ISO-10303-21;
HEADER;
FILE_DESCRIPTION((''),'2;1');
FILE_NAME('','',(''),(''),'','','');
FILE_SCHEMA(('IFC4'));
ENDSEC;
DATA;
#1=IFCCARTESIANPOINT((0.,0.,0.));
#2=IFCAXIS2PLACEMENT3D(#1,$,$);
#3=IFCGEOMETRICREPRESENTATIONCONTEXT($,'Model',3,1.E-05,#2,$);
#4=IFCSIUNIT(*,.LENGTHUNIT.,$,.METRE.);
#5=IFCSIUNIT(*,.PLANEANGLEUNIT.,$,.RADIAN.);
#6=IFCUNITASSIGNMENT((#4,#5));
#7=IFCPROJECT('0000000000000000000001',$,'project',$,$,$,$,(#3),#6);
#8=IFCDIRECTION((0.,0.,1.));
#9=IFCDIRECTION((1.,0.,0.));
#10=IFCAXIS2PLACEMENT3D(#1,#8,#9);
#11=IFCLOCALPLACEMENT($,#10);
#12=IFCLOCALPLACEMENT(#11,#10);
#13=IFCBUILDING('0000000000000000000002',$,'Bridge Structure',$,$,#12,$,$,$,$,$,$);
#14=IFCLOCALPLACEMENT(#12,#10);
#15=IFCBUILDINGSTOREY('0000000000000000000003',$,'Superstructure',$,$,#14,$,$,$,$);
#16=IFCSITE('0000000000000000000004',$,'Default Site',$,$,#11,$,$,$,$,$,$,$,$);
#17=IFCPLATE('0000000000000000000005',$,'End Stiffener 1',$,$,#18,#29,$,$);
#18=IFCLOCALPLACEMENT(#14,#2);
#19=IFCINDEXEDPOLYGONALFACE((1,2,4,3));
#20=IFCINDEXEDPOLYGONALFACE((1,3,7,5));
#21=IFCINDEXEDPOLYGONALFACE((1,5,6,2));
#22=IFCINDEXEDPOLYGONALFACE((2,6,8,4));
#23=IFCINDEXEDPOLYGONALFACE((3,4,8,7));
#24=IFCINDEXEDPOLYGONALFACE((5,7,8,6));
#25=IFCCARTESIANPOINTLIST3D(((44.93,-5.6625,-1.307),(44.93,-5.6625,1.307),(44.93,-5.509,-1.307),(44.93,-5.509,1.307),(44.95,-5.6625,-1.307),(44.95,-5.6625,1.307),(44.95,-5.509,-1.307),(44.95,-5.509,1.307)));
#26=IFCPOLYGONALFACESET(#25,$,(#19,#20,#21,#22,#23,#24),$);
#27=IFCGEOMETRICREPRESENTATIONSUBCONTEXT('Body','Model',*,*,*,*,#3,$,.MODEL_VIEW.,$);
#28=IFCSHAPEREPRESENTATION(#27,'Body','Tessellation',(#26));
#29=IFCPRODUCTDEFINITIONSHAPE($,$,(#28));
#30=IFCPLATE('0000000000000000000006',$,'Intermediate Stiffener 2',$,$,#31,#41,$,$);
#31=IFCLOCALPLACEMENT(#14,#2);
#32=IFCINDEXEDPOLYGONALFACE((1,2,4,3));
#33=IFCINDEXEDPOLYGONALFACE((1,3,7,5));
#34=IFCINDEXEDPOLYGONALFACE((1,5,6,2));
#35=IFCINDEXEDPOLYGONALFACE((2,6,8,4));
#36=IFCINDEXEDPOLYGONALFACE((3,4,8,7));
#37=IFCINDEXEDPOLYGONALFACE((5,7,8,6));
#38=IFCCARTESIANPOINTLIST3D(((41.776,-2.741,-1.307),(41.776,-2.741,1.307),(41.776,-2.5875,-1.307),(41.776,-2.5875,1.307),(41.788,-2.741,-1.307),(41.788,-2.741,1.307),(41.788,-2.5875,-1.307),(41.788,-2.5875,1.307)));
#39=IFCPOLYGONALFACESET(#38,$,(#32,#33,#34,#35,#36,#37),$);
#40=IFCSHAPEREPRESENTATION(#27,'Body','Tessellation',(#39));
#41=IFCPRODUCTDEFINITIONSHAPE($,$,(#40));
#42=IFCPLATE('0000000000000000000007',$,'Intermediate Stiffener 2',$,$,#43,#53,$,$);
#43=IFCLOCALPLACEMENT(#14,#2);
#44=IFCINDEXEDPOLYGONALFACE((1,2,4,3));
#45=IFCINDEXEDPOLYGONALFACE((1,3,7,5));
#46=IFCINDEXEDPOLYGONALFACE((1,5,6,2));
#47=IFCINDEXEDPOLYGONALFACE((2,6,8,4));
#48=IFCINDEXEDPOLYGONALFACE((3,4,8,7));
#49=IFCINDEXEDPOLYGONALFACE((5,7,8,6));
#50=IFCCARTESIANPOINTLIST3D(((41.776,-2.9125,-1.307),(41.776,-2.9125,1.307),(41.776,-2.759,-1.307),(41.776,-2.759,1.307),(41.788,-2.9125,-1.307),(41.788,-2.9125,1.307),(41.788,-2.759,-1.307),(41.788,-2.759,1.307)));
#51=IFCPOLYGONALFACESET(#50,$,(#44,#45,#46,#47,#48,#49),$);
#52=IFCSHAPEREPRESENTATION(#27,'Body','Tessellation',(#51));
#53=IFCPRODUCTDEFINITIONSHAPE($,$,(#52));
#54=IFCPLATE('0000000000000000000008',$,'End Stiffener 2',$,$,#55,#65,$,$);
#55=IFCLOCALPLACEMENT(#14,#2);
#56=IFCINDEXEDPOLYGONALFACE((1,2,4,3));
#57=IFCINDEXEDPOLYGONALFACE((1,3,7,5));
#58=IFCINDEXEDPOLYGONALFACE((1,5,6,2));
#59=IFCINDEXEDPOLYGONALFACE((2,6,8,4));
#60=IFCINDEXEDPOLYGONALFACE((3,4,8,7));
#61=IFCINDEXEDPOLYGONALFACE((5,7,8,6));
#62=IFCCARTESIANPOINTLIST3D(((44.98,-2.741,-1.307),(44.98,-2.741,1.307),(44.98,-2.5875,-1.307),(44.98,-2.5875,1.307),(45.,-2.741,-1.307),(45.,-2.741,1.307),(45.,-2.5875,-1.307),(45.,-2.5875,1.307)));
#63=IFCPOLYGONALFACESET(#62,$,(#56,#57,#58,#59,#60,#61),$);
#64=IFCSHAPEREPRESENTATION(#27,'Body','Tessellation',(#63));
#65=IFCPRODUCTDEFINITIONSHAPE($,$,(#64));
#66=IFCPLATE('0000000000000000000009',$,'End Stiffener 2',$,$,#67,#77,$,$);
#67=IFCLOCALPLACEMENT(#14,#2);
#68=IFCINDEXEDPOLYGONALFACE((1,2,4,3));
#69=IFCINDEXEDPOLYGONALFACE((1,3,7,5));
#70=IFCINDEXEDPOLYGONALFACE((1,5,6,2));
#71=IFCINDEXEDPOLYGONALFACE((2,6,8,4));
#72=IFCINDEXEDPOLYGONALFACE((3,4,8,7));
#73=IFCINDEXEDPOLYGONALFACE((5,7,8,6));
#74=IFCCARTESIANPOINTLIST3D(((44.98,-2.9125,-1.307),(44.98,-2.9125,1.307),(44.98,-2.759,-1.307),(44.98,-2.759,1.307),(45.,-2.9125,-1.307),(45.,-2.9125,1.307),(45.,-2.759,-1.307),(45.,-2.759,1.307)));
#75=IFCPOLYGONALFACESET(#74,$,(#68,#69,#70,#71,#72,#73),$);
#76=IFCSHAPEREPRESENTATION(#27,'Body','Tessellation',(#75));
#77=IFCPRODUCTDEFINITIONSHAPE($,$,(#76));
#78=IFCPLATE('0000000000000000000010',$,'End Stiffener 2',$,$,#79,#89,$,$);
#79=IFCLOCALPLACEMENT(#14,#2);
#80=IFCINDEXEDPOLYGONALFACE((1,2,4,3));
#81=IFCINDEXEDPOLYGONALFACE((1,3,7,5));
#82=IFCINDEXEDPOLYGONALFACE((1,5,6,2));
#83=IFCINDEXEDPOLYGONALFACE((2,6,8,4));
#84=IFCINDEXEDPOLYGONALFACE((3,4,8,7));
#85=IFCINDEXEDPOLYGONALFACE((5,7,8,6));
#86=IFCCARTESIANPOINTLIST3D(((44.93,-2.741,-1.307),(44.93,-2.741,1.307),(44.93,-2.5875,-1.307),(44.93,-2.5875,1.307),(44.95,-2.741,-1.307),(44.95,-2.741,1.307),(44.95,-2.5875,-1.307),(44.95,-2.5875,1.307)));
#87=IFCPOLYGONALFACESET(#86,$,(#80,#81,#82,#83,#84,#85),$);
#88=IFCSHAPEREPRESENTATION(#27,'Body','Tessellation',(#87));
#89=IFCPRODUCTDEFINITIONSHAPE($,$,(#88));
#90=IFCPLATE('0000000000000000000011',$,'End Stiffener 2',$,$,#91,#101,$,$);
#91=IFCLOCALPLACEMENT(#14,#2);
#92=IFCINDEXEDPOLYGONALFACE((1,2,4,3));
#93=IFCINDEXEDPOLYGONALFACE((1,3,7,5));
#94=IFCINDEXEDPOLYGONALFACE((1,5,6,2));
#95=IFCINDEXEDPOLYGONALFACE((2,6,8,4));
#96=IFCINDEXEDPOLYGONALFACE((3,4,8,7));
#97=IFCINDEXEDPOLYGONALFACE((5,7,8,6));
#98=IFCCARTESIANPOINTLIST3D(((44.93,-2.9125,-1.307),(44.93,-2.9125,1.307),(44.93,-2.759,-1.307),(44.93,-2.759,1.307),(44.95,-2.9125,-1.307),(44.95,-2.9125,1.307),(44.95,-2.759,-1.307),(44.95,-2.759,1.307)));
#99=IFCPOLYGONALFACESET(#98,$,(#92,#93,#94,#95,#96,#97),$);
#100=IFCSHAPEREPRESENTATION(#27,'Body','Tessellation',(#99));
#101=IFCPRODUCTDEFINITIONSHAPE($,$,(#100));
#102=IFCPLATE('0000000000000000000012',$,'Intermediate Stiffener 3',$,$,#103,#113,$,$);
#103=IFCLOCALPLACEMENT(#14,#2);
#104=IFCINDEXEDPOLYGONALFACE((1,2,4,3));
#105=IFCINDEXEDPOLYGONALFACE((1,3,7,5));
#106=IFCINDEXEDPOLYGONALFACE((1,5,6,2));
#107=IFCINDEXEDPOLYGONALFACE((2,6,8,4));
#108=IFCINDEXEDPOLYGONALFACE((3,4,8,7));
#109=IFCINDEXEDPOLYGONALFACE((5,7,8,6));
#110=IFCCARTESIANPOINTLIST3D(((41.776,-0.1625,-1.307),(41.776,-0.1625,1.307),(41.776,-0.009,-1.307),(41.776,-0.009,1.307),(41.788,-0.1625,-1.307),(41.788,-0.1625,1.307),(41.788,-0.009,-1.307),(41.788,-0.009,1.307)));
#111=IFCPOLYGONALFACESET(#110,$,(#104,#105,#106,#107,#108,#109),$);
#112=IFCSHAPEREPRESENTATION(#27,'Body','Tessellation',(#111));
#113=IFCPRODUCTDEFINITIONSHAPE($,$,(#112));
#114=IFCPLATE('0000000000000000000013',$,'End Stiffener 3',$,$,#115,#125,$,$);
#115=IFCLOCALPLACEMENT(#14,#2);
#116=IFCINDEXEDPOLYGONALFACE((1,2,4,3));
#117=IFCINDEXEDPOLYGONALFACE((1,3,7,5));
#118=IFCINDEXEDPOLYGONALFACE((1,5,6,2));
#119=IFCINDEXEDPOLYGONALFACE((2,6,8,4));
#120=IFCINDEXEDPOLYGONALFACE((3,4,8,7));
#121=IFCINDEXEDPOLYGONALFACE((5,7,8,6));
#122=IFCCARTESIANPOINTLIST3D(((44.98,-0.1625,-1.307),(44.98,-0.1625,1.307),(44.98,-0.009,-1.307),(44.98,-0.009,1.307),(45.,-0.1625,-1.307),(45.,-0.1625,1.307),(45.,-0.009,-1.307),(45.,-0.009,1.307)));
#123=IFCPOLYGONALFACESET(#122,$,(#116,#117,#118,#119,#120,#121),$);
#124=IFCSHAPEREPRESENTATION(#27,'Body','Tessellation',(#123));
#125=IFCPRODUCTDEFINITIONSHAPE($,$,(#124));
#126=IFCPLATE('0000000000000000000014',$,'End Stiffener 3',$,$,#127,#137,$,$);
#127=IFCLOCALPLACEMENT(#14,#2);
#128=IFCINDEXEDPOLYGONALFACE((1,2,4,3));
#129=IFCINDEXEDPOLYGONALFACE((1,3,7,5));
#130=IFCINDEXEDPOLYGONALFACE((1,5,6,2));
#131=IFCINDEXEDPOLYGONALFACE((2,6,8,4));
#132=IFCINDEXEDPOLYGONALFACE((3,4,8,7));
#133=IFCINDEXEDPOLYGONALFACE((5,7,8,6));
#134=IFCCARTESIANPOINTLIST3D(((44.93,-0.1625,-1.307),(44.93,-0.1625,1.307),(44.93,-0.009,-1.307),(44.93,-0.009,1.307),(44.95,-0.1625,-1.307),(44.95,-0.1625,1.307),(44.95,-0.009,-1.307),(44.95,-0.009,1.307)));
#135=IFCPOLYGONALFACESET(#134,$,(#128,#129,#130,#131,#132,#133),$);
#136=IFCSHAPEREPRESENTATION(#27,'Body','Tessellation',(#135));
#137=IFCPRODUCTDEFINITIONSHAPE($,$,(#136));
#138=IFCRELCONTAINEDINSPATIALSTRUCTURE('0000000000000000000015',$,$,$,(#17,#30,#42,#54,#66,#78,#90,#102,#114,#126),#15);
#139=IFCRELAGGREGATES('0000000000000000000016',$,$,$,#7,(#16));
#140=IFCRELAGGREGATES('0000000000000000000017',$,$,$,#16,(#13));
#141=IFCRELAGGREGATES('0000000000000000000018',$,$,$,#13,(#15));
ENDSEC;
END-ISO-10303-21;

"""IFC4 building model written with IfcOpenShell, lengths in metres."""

from ifc_helpers import new_model, si_unit, frame, origin, origin_with_axes, origin_2d_with_axis, place, context, subcontext, project, spatial, rectangle, extrude, element, save


model = new_model("IFC4")

# Units and contexts
model_context = context("Model", 3, precision=1e-05, world=origin())
body_context = subcontext(model_context, "Body", "Model", "MODEL_VIEW")
ifc_project = project(units=[si_unit("LENGTHUNIT", "METRE"), si_unit("PLANEANGLEUNIT", "RADIAN")], contexts=[model_context])

# Site, building, storey
site_placement = place(None, origin_with_axes())
site = spatial("IfcSite", under=ifc_project, at=site_placement, Name="Default Site")
building_placement = place(site_placement, origin_with_axes())
building = spatial("IfcBuilding", under=site, at=building_placement, Name="Bridge Structure")
storey_placement = place(building_placement, origin_with_axes())
storey = spatial("IfcBuildingStorey", under=building, at=storey_placement, Name="Superstructure")

# Plates
for number, where, z_axis, x_axis, name in (
    (1, (44.94, -5.5857, -1.307), (0.0, 0.0, 1.0), (1.0, 0.0, 0.0), "End Stiffener 1"),
):
    element("IfcPlate", number, at=place(storey_placement, frame(where, z_axis=z_axis, x_axis=x_axis)), inside=storey, Name=name, context=body_context, shape_type="SweptSolid", body=[
        extrude(rectangle(XDim=0.02, YDim=0.1535, at=origin_2d_with_axis()), origin_with_axes(), (0.0, 0.0, 1.0), 2.614),
    ])
for number, where, z_axis, x_axis, name in (
    (2, (41.782, -2.6643, -1.307), (0.0, 0.0, 1.0), (1.0, 0.0, 0.0), "Intermediate Stiffener 2"),
    (3, (41.782, -2.8357, -1.307), (0.0, 0.0, 1.0), (1.0, 0.0, 0.0), "Intermediate Stiffener 2"),
):
    element("IfcPlate", number, at=place(storey_placement, frame(where, z_axis=z_axis, x_axis=x_axis)), inside=storey, Name=name, context=body_context, shape_type="SweptSolid", body=[
        extrude(rectangle(XDim=0.012, YDim=0.1535, at=origin_2d_with_axis()), origin_with_axes(), (0.0, 0.0, 1.0), 2.614),
    ])
for number, where, z_axis, x_axis, name in (
    (4, (44.99, -2.6643, -1.307), (0.0, 0.0, 1.0), (1.0, 0.0, 0.0), "End Stiffener 2"),
    (5, (44.99, -2.8357, -1.307), (0.0, 0.0, 1.0), (1.0, 0.0, 0.0), "End Stiffener 2"),
    (6, (44.94, -2.6643, -1.307), (0.0, 0.0, 1.0), (1.0, 0.0, 0.0), "End Stiffener 2"),
    (7, (44.94, -2.8357, -1.307), (0.0, 0.0, 1.0), (1.0, 0.0, 0.0), "End Stiffener 2"),
):
    element("IfcPlate", number, at=place(storey_placement, frame(where, z_axis=z_axis, x_axis=x_axis)), inside=storey, Name=name, context=body_context, shape_type="SweptSolid", body=[
        extrude(rectangle(XDim=0.02, YDim=0.1535, at=origin_2d_with_axis()), origin_with_axes(), (0.0, 0.0, 1.0), 2.614),
    ])
plate_placement = place(storey_placement, frame((41.782, -0.0858, -1.307), z_axis=(0.0, 0.0, 1.0), x_axis=(1.0, 0.0, 0.0)))
element("IfcPlate", 8, at=plate_placement, inside=storey, Name="Intermediate Stiffener 3", context=body_context, shape_type="SweptSolid", body=[
    extrude(rectangle(XDim=0.012, YDim=0.1535, at=origin_2d_with_axis()), origin_with_axes(), (0.0, 0.0, 1.0), 2.614),
])
for number, where, z_axis, x_axis, name in (
    (9, (44.99, -0.0858, -1.307), (0.0, 0.0, 1.0), (1.0, 0.0, 0.0), "End Stiffener 3"),
    (10, (44.94, -0.0858, -1.307), (0.0, 0.0, 1.0), (1.0, 0.0, 0.0), "End Stiffener 3"),
):
    element("IfcPlate", number, at=place(storey_placement, frame(where, z_axis=z_axis, x_axis=x_axis)), inside=storey, Name=name, context=body_context, shape_type="SweptSolid", body=[
        extrude(rectangle(XDim=0.02, YDim=0.1535, at=origin_2d_with_axis()), origin_with_axes(), (0.0, 0.0, 1.0), 2.614),
    ])

save(model, "model.ifc")
